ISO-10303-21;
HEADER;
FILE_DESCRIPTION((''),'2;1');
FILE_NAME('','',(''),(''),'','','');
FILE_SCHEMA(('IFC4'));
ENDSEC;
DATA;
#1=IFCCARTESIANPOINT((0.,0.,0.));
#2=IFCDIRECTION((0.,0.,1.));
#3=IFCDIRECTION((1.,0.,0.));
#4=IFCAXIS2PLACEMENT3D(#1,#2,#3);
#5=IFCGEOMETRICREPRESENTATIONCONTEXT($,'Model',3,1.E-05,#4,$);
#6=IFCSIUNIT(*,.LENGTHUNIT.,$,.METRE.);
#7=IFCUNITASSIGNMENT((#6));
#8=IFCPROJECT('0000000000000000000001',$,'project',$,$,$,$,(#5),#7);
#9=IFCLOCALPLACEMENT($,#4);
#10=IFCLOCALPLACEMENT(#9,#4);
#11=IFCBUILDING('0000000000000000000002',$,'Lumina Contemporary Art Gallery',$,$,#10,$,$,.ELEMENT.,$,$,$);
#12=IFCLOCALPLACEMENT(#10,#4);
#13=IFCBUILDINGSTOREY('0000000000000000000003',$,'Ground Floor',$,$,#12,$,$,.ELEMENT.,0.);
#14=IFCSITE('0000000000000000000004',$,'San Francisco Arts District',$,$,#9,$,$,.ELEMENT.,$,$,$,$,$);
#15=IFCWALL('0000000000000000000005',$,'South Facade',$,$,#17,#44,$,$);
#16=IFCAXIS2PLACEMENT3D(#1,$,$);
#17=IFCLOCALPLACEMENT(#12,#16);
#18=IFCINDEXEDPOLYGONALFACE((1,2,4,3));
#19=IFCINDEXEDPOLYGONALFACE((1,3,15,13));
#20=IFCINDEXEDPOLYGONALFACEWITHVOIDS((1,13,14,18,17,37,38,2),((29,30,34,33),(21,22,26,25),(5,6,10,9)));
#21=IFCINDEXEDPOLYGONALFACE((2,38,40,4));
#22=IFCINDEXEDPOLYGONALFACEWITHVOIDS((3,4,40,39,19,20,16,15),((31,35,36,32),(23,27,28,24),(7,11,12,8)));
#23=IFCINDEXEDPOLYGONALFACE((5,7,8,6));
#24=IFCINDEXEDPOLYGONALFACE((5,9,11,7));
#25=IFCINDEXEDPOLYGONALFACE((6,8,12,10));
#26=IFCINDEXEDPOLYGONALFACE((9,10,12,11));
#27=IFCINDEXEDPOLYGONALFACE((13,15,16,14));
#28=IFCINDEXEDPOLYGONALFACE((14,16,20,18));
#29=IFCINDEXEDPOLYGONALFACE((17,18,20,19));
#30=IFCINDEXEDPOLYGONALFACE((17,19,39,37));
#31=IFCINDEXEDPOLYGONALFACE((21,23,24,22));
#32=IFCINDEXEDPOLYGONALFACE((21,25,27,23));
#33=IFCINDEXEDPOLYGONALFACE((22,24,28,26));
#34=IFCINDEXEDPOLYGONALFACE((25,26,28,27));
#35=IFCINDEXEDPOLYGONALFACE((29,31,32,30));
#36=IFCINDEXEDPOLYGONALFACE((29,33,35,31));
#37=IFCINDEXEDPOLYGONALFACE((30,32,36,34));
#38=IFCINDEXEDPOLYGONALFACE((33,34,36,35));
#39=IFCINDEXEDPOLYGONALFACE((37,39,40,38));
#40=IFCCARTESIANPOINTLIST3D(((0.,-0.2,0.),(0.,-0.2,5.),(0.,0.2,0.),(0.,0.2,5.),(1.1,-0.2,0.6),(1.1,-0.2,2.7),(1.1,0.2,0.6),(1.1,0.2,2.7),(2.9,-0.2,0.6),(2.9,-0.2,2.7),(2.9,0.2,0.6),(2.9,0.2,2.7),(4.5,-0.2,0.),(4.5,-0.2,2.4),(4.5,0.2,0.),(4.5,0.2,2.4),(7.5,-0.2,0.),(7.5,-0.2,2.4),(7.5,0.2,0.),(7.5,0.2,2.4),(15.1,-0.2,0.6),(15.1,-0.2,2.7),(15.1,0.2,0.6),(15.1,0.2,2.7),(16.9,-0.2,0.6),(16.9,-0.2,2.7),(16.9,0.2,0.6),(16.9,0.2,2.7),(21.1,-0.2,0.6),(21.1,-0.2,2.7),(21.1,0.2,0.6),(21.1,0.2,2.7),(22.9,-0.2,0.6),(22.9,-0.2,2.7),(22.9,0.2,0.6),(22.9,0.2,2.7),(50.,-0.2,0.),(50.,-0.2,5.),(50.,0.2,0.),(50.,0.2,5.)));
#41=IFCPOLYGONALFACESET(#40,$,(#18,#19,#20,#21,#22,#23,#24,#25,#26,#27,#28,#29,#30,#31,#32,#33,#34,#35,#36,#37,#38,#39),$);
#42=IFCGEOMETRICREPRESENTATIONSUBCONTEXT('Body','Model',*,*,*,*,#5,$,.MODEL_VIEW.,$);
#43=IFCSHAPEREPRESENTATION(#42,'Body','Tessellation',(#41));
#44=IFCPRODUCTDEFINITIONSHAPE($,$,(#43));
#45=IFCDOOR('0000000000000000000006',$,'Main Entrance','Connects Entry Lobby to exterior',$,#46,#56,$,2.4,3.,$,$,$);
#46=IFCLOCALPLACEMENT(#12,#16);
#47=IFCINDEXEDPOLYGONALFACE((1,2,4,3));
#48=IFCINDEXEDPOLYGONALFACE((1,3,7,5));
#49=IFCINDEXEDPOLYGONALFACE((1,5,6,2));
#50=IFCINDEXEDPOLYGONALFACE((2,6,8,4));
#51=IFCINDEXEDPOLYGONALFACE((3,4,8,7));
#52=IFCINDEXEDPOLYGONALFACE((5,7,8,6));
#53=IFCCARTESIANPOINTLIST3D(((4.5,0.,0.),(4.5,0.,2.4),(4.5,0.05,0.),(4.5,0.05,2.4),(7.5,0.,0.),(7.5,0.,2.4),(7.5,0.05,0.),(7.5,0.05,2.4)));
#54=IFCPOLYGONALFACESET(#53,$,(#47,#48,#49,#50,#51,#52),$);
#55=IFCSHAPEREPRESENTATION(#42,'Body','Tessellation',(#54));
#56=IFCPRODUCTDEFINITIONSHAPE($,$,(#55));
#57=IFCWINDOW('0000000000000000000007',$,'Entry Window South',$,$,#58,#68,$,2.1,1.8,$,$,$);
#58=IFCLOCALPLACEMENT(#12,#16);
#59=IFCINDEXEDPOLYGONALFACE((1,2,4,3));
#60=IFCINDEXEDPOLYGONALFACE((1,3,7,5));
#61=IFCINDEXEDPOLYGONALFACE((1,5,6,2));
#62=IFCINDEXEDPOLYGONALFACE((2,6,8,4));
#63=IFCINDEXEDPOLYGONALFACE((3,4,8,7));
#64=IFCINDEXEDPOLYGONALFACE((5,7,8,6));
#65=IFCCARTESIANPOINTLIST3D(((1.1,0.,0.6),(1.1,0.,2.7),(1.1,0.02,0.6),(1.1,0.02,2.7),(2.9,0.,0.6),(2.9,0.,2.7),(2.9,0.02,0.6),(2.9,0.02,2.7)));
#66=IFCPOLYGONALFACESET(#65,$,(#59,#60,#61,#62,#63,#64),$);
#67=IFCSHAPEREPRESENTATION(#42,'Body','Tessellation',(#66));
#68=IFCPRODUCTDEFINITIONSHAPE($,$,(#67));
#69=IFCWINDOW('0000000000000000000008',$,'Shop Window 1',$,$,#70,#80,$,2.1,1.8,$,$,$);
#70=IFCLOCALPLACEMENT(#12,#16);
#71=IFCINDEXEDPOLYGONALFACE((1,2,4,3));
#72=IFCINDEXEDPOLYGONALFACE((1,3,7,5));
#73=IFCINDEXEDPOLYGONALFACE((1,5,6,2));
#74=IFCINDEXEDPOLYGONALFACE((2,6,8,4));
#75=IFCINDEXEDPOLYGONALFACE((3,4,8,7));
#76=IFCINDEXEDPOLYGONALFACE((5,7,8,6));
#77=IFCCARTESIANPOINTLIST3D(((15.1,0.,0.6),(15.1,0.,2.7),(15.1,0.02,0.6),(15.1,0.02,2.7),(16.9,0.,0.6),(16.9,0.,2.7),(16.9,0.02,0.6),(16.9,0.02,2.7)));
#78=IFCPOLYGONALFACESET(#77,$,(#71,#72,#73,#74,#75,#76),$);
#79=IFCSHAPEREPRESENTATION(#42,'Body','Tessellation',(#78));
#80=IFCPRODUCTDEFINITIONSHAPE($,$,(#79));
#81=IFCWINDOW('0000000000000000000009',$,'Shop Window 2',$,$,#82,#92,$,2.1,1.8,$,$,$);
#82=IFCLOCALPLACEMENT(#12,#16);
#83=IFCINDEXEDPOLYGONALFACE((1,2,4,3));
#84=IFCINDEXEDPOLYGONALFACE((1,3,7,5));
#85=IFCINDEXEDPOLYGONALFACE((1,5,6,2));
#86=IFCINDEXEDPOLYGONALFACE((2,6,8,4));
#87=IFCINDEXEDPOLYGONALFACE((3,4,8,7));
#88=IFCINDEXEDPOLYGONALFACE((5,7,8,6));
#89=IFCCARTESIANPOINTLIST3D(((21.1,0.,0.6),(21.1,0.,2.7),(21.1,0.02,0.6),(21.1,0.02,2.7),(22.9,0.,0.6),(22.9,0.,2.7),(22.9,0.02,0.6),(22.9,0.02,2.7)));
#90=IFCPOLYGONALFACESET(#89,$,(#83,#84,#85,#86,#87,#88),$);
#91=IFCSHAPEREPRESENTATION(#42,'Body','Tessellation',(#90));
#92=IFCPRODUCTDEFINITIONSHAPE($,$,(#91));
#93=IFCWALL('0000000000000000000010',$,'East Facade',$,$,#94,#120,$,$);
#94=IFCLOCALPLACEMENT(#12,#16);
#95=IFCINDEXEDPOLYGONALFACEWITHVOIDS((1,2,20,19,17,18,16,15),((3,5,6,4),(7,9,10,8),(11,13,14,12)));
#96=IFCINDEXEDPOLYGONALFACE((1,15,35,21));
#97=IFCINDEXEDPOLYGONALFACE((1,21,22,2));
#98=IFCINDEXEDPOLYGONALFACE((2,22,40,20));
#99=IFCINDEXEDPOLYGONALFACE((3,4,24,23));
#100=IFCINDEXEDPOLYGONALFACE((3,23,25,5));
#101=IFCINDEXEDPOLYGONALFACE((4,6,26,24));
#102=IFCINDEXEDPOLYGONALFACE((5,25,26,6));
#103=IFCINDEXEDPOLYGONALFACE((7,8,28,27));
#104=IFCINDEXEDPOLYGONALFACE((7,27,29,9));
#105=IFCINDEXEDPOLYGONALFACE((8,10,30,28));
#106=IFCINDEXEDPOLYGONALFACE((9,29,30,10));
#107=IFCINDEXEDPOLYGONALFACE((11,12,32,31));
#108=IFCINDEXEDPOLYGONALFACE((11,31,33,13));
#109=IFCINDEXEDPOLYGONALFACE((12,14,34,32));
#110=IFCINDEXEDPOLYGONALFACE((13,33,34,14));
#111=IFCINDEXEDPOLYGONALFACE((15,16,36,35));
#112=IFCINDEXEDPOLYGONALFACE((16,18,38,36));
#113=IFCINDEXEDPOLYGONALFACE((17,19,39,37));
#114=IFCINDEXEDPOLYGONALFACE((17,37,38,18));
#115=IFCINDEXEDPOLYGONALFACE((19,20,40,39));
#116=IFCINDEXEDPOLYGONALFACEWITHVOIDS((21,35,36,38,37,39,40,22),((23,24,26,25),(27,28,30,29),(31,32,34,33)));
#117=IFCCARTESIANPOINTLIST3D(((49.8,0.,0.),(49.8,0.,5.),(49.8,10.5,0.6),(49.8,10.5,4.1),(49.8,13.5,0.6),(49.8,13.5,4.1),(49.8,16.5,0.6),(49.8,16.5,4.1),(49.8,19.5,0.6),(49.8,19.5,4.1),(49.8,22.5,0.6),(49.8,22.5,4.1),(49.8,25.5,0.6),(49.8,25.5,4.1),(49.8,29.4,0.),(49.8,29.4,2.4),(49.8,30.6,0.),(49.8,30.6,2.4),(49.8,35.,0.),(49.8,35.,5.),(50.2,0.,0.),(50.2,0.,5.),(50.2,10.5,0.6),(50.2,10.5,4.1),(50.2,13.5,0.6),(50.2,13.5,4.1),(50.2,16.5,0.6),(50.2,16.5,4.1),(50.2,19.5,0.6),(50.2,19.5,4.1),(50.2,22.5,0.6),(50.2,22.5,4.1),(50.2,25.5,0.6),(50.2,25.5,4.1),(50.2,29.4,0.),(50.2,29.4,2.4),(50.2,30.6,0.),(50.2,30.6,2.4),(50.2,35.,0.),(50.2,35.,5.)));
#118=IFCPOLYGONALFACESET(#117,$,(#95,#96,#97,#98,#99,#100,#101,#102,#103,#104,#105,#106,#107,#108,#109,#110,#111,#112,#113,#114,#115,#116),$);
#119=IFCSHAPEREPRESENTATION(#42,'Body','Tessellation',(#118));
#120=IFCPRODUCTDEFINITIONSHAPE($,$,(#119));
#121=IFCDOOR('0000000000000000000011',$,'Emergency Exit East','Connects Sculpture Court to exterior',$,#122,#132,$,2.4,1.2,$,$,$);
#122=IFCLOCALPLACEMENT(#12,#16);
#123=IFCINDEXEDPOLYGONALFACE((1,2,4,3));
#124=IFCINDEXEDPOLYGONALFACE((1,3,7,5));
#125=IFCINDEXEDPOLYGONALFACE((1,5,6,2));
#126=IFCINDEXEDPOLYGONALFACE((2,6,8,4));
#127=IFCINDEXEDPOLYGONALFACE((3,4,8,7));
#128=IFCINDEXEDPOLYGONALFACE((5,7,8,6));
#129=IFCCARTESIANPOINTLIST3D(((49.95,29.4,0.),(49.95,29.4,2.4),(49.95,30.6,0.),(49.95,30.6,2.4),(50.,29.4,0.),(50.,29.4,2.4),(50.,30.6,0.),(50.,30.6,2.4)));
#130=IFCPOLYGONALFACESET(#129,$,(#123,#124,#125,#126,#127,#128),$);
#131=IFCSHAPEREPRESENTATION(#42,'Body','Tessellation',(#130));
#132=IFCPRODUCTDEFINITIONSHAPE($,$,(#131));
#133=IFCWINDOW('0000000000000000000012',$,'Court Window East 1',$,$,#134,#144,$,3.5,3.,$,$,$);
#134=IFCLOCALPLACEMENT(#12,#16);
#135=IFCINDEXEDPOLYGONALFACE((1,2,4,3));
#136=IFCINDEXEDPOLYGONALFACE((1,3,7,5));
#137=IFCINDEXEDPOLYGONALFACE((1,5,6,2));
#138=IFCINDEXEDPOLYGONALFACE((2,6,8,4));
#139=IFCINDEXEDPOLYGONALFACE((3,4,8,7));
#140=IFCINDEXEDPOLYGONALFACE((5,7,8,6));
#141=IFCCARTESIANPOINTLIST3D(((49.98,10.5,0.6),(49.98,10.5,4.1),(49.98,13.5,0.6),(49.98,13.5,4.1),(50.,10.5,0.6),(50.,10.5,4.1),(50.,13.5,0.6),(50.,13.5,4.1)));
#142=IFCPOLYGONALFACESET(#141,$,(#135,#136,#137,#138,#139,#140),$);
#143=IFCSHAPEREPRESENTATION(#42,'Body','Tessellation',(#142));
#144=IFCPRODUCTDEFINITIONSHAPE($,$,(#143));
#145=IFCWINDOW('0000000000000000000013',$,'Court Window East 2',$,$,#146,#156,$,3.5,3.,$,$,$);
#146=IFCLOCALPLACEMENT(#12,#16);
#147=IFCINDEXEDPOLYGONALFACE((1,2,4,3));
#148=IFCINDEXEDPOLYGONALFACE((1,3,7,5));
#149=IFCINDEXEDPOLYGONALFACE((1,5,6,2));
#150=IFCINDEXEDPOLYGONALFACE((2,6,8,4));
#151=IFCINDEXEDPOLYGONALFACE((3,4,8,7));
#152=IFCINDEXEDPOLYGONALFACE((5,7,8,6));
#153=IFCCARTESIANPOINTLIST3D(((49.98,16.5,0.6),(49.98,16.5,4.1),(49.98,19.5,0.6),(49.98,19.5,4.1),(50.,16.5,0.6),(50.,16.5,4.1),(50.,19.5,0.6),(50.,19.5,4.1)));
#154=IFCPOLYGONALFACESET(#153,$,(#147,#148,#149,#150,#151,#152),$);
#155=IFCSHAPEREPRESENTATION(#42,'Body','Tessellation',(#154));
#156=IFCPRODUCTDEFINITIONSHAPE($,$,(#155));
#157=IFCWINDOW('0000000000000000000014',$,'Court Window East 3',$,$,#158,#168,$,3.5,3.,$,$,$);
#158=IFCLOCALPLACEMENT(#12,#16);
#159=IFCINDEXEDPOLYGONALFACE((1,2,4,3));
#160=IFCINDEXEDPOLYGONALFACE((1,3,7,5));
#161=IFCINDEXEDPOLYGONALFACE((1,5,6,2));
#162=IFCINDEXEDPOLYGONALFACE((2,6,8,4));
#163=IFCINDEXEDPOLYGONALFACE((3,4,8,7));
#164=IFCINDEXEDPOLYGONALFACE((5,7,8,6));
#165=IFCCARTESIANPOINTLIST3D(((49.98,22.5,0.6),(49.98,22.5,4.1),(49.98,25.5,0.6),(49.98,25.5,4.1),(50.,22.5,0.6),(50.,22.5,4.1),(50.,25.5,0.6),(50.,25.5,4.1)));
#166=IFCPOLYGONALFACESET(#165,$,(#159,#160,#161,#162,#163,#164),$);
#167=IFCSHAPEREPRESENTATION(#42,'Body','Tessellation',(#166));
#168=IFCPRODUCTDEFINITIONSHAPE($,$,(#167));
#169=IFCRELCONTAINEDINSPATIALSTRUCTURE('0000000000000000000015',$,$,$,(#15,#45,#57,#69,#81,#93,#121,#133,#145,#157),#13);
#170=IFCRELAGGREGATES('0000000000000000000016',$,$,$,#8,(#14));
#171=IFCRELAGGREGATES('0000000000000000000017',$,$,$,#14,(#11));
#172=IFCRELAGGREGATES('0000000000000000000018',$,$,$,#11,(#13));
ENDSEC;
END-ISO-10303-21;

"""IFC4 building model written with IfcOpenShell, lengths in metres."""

from ifc_helpers import new_model, si_unit, origin_with_axes, place, context, subcontext, project, spatial, polyline, outline, extrude, element, fill, save


model = new_model("IFC4")

# Units and contexts
model_context = context("Model", 3, precision=1e-05, world=origin_with_axes())
body_context = subcontext(model_context, "Body", "Model", "MODEL_VIEW")
ifc_project = project(units=[si_unit("LENGTHUNIT", "METRE")], contexts=[model_context])

# Site, building, storey
site_placement = place(None, origin_with_axes())
site = spatial("IfcSite", under=ifc_project, at=site_placement, Name="San Francisco Arts District", CompositionType="ELEMENT")
building_placement = place(site_placement, origin_with_axes())
building = spatial("IfcBuilding", under=site, at=building_placement, Name="Lumina Contemporary Art Gallery", CompositionType="ELEMENT")
storey_placement = place(building_placement, origin_with_axes())
storey = spatial("IfcBuildingStorey", under=building, at=storey_placement, Name="Ground Floor", CompositionType="ELEMENT", Elevation=0.0)

# Walls, openings, doors, windows
wall_1_placement = place(storey_placement, origin_with_axes())
wall_1 = element("IfcWall", 1, at=wall_1_placement, inside=storey, Name="South Facade", context=body_context, shape_type="SweptSolid", body=[
    extrude(outline(polyline([(0.0, -0.2, 0.0), (50.0, -0.2, 0.0), (50.0, 0.2, 0.0), (0.0, 0.2, 0.0), (0.0, -0.2, 0.0)])), None, (0.0, 0.0, 1.0), 5.0),
])
opening_1_placement = place(storey_placement, origin_with_axes())
opening_1 = element("IfcOpeningElement", 2, at=opening_1_placement, inside=storey, cuts=wall_1, context=body_context, shape_type="SweptSolid", body=[
    extrude(outline(polyline([(4.5, -0.4, 0.0), (7.5, -0.4, 0.0), (7.5, 0.4, 0.0), (4.5, 0.4, 0.0), (4.5, -0.4, 0.0)])), None, (0.0, 0.0, 1.0), 2.4),
])
opening_2_placement = place(storey_placement, origin_with_axes())
opening_2 = element("IfcOpeningElement", 3, at=opening_2_placement, inside=storey, cuts=wall_1, context=body_context, shape_type="SweptSolid", body=[
    extrude(outline(polyline([(1.1, -0.4, 0.6), (2.9, -0.4, 0.6), (2.9, 0.4, 0.6), (1.1, 0.4, 0.6), (1.1, -0.4, 0.6)])), None, (0.0, 0.0, 1.0), 2.1),
])
opening_3_placement = place(storey_placement, origin_with_axes())
opening_3 = element("IfcOpeningElement", 4, at=opening_3_placement, inside=storey, cuts=wall_1, context=body_context, shape_type="SweptSolid", body=[
    extrude(outline(polyline([(15.1, -0.4, 0.6), (16.9, -0.4, 0.6), (16.9, 0.4, 0.6), (15.1, 0.4, 0.6), (15.1, -0.4, 0.6)])), None, (0.0, 0.0, 1.0), 2.1),
])
opening_4_placement = place(storey_placement, origin_with_axes())
opening_4 = element("IfcOpeningElement", 5, at=opening_4_placement, inside=storey, cuts=wall_1, context=body_context, shape_type="SweptSolid", body=[
    extrude(outline(polyline([(21.1, -0.4, 0.6), (22.9, -0.4, 0.6), (22.9, 0.4, 0.6), (21.1, 0.4, 0.6), (21.1, -0.4, 0.6)])), None, (0.0, 0.0, 1.0), 2.1),
])
door_1_placement = place(storey_placement, origin_with_axes())
door_1 = element("IfcDoor", 6, at=door_1_placement, inside=storey, Name="Main Entrance", Description="Connects Entry Lobby to exterior", OverallHeight=2.4, OverallWidth=3.0, context=body_context, shape_type="SweptSolid", body=[
    extrude(outline(polyline([(4.5, 0.0, 0.0), (7.5, 0.0, 0.0), (7.5, 0.05, 0.0), (4.5, 0.05, 0.0), (4.5, 0.0, 0.0)])), None, (0.0, 0.0, 1.0), 2.4),
])
fill(opening_1, door_1)
window_1_placement = place(storey_placement, origin_with_axes())
window_1 = element("IfcWindow", 7, at=window_1_placement, inside=storey, Name="Entry Window South", OverallHeight=2.1, OverallWidth=1.8, context=body_context, shape_type="SweptSolid", body=[
    extrude(outline(polyline([(1.1, 0.0, 0.6), (2.9, 0.0, 0.6), (2.9, 0.02, 0.6), (1.1, 0.02, 0.6), (1.1, 0.0, 0.6)])), None, (0.0, 0.0, 1.0), 2.1),
])
fill(opening_2, window_1)
window_2_placement = place(storey_placement, origin_with_axes())
window_2 = element("IfcWindow", 8, at=window_2_placement, inside=storey, Name="Shop Window 1", OverallHeight=2.1, OverallWidth=1.8, context=body_context, shape_type="SweptSolid", body=[
    extrude(outline(polyline([(15.1, 0.0, 0.6), (16.9, 0.0, 0.6), (16.9, 0.02, 0.6), (15.1, 0.02, 0.6), (15.1, 0.0, 0.6)])), None, (0.0, 0.0, 1.0), 2.1),
])
fill(opening_3, window_2)
window_3_placement = place(storey_placement, origin_with_axes())
window_3 = element("IfcWindow", 9, at=window_3_placement, inside=storey, Name="Shop Window 2", OverallHeight=2.1, OverallWidth=1.8, context=body_context, shape_type="SweptSolid", body=[
    extrude(outline(polyline([(21.1, 0.0, 0.6), (22.9, 0.0, 0.6), (22.9, 0.02, 0.6), (21.1, 0.02, 0.6), (21.1, 0.0, 0.6)])), None, (0.0, 0.0, 1.0), 2.1),
])
fill(opening_4, window_3)
wall_2_placement = place(storey_placement, origin_with_axes())
wall_2 = element("IfcWall", 10, at=wall_2_placement, inside=storey, Name="East Facade", context=body_context, shape_type="SweptSolid", body=[
    extrude(outline(polyline([(50.2, 0.0, 0.0), (50.2, 35.0, 0.0), (49.8, 35.0, 0.0), (49.8, 0.0, 0.0), (50.2, 0.0, 0.0)])), None, (0.0, 0.0, 1.0), 5.0),
])
opening_5_placement = place(storey_placement, origin_with_axes())
opening_5 = element("IfcOpeningElement", 11, at=opening_5_placement, inside=storey, cuts=wall_2, context=body_context, shape_type="SweptSolid", body=[
    extrude(outline(polyline([(50.4, 29.4, 0.0), (50.4, 30.6, 0.0), (49.6, 30.6, 0.0), (49.6, 29.4, 0.0), (50.4, 29.4, 0.0)])), None, (0.0, 0.0, 1.0), 2.4),
])
opening_6_placement = place(storey_placement, origin_with_axes())
opening_6 = element("IfcOpeningElement", 12, at=opening_6_placement, inside=storey, cuts=wall_2, context=body_context, shape_type="SweptSolid", body=[
    extrude(outline(polyline([(50.4, 10.5, 0.6), (50.4, 13.5, 0.6), (49.6, 13.5, 0.6), (49.6, 10.5, 0.6), (50.4, 10.5, 0.6)])), None, (0.0, 0.0, 1.0), 3.5),
])
opening_7_placement = place(storey_placement, origin_with_axes())
opening_7 = element("IfcOpeningElement", 13, at=opening_7_placement, inside=storey, cuts=wall_2, context=body_context, shape_type="SweptSolid", body=[
    extrude(outline(polyline([(50.4, 16.5, 0.6), (50.4, 19.5, 0.6), (49.6, 19.5, 0.6), (49.6, 16.5, 0.6), (50.4, 16.5, 0.6)])), None, (0.0, 0.0, 1.0), 3.5),
])
opening_8_placement = place(storey_placement, origin_with_axes())
opening_8 = element("IfcOpeningElement", 14, at=opening_8_placement, inside=storey, cuts=wall_2, context=body_context, shape_type="SweptSolid", body=[
    extrude(outline(polyline([(50.4, 22.5, 0.6), (50.4, 25.5, 0.6), (49.6, 25.5, 0.6), (49.6, 22.5, 0.6), (50.4, 22.5, 0.6)])), None, (0.0, 0.0, 1.0), 3.5),
])
door_2_placement = place(storey_placement, origin_with_axes())
door_2 = element("IfcDoor", 15, at=door_2_placement, inside=storey, Name="Emergency Exit East", Description="Connects Sculpture Court to exterior", OverallHeight=2.4, OverallWidth=1.2, context=body_context, shape_type="SweptSolid", body=[
    extrude(outline(polyline([(50.0, 29.4, 0.0), (50.0, 30.6, 0.0), (49.95, 30.6, 0.0), (49.95, 29.4, 0.0), (50.0, 29.4, 0.0)])), None, (0.0, 0.0, 1.0), 2.4),
])
fill(opening_5, door_2)
window_4_placement = place(storey_placement, origin_with_axes())
window_4 = element("IfcWindow", 16, at=window_4_placement, inside=storey, Name="Court Window East 1", OverallHeight=3.5, OverallWidth=3.0, context=body_context, shape_type="SweptSolid", body=[
    extrude(outline(polyline([(50.0, 10.5, 0.6), (50.0, 13.5, 0.6), (49.98, 13.5, 0.6), (49.98, 10.5, 0.6), (50.0, 10.5, 0.6)])), None, (0.0, 0.0, 1.0), 3.5),
])
fill(opening_6, window_4)
window_5_placement = place(storey_placement, origin_with_axes())
window_5 = element("IfcWindow", 17, at=window_5_placement, inside=storey, Name="Court Window East 2", OverallHeight=3.5, OverallWidth=3.0, context=body_context, shape_type="SweptSolid", body=[
    extrude(outline(polyline([(50.0, 16.5, 0.6), (50.0, 19.5, 0.6), (49.98, 19.5, 0.6), (49.98, 16.5, 0.6), (50.0, 16.5, 0.6)])), None, (0.0, 0.0, 1.0), 3.5),
])
fill(opening_7, window_5)
window_6_placement = place(storey_placement, origin_with_axes())
window_6 = element("IfcWindow", 18, at=window_6_placement, inside=storey, Name="Court Window East 3", OverallHeight=3.5, OverallWidth=3.0, context=body_context, shape_type="SweptSolid", body=[
    extrude(outline(polyline([(50.0, 22.5, 0.6), (50.0, 25.5, 0.6), (49.98, 25.5, 0.6), (49.98, 22.5, 0.6), (50.0, 22.5, 0.6)])), None, (0.0, 0.0, 1.0), 3.5),
])
fill(opening_8, window_6)

save(model, "model.ifc")
